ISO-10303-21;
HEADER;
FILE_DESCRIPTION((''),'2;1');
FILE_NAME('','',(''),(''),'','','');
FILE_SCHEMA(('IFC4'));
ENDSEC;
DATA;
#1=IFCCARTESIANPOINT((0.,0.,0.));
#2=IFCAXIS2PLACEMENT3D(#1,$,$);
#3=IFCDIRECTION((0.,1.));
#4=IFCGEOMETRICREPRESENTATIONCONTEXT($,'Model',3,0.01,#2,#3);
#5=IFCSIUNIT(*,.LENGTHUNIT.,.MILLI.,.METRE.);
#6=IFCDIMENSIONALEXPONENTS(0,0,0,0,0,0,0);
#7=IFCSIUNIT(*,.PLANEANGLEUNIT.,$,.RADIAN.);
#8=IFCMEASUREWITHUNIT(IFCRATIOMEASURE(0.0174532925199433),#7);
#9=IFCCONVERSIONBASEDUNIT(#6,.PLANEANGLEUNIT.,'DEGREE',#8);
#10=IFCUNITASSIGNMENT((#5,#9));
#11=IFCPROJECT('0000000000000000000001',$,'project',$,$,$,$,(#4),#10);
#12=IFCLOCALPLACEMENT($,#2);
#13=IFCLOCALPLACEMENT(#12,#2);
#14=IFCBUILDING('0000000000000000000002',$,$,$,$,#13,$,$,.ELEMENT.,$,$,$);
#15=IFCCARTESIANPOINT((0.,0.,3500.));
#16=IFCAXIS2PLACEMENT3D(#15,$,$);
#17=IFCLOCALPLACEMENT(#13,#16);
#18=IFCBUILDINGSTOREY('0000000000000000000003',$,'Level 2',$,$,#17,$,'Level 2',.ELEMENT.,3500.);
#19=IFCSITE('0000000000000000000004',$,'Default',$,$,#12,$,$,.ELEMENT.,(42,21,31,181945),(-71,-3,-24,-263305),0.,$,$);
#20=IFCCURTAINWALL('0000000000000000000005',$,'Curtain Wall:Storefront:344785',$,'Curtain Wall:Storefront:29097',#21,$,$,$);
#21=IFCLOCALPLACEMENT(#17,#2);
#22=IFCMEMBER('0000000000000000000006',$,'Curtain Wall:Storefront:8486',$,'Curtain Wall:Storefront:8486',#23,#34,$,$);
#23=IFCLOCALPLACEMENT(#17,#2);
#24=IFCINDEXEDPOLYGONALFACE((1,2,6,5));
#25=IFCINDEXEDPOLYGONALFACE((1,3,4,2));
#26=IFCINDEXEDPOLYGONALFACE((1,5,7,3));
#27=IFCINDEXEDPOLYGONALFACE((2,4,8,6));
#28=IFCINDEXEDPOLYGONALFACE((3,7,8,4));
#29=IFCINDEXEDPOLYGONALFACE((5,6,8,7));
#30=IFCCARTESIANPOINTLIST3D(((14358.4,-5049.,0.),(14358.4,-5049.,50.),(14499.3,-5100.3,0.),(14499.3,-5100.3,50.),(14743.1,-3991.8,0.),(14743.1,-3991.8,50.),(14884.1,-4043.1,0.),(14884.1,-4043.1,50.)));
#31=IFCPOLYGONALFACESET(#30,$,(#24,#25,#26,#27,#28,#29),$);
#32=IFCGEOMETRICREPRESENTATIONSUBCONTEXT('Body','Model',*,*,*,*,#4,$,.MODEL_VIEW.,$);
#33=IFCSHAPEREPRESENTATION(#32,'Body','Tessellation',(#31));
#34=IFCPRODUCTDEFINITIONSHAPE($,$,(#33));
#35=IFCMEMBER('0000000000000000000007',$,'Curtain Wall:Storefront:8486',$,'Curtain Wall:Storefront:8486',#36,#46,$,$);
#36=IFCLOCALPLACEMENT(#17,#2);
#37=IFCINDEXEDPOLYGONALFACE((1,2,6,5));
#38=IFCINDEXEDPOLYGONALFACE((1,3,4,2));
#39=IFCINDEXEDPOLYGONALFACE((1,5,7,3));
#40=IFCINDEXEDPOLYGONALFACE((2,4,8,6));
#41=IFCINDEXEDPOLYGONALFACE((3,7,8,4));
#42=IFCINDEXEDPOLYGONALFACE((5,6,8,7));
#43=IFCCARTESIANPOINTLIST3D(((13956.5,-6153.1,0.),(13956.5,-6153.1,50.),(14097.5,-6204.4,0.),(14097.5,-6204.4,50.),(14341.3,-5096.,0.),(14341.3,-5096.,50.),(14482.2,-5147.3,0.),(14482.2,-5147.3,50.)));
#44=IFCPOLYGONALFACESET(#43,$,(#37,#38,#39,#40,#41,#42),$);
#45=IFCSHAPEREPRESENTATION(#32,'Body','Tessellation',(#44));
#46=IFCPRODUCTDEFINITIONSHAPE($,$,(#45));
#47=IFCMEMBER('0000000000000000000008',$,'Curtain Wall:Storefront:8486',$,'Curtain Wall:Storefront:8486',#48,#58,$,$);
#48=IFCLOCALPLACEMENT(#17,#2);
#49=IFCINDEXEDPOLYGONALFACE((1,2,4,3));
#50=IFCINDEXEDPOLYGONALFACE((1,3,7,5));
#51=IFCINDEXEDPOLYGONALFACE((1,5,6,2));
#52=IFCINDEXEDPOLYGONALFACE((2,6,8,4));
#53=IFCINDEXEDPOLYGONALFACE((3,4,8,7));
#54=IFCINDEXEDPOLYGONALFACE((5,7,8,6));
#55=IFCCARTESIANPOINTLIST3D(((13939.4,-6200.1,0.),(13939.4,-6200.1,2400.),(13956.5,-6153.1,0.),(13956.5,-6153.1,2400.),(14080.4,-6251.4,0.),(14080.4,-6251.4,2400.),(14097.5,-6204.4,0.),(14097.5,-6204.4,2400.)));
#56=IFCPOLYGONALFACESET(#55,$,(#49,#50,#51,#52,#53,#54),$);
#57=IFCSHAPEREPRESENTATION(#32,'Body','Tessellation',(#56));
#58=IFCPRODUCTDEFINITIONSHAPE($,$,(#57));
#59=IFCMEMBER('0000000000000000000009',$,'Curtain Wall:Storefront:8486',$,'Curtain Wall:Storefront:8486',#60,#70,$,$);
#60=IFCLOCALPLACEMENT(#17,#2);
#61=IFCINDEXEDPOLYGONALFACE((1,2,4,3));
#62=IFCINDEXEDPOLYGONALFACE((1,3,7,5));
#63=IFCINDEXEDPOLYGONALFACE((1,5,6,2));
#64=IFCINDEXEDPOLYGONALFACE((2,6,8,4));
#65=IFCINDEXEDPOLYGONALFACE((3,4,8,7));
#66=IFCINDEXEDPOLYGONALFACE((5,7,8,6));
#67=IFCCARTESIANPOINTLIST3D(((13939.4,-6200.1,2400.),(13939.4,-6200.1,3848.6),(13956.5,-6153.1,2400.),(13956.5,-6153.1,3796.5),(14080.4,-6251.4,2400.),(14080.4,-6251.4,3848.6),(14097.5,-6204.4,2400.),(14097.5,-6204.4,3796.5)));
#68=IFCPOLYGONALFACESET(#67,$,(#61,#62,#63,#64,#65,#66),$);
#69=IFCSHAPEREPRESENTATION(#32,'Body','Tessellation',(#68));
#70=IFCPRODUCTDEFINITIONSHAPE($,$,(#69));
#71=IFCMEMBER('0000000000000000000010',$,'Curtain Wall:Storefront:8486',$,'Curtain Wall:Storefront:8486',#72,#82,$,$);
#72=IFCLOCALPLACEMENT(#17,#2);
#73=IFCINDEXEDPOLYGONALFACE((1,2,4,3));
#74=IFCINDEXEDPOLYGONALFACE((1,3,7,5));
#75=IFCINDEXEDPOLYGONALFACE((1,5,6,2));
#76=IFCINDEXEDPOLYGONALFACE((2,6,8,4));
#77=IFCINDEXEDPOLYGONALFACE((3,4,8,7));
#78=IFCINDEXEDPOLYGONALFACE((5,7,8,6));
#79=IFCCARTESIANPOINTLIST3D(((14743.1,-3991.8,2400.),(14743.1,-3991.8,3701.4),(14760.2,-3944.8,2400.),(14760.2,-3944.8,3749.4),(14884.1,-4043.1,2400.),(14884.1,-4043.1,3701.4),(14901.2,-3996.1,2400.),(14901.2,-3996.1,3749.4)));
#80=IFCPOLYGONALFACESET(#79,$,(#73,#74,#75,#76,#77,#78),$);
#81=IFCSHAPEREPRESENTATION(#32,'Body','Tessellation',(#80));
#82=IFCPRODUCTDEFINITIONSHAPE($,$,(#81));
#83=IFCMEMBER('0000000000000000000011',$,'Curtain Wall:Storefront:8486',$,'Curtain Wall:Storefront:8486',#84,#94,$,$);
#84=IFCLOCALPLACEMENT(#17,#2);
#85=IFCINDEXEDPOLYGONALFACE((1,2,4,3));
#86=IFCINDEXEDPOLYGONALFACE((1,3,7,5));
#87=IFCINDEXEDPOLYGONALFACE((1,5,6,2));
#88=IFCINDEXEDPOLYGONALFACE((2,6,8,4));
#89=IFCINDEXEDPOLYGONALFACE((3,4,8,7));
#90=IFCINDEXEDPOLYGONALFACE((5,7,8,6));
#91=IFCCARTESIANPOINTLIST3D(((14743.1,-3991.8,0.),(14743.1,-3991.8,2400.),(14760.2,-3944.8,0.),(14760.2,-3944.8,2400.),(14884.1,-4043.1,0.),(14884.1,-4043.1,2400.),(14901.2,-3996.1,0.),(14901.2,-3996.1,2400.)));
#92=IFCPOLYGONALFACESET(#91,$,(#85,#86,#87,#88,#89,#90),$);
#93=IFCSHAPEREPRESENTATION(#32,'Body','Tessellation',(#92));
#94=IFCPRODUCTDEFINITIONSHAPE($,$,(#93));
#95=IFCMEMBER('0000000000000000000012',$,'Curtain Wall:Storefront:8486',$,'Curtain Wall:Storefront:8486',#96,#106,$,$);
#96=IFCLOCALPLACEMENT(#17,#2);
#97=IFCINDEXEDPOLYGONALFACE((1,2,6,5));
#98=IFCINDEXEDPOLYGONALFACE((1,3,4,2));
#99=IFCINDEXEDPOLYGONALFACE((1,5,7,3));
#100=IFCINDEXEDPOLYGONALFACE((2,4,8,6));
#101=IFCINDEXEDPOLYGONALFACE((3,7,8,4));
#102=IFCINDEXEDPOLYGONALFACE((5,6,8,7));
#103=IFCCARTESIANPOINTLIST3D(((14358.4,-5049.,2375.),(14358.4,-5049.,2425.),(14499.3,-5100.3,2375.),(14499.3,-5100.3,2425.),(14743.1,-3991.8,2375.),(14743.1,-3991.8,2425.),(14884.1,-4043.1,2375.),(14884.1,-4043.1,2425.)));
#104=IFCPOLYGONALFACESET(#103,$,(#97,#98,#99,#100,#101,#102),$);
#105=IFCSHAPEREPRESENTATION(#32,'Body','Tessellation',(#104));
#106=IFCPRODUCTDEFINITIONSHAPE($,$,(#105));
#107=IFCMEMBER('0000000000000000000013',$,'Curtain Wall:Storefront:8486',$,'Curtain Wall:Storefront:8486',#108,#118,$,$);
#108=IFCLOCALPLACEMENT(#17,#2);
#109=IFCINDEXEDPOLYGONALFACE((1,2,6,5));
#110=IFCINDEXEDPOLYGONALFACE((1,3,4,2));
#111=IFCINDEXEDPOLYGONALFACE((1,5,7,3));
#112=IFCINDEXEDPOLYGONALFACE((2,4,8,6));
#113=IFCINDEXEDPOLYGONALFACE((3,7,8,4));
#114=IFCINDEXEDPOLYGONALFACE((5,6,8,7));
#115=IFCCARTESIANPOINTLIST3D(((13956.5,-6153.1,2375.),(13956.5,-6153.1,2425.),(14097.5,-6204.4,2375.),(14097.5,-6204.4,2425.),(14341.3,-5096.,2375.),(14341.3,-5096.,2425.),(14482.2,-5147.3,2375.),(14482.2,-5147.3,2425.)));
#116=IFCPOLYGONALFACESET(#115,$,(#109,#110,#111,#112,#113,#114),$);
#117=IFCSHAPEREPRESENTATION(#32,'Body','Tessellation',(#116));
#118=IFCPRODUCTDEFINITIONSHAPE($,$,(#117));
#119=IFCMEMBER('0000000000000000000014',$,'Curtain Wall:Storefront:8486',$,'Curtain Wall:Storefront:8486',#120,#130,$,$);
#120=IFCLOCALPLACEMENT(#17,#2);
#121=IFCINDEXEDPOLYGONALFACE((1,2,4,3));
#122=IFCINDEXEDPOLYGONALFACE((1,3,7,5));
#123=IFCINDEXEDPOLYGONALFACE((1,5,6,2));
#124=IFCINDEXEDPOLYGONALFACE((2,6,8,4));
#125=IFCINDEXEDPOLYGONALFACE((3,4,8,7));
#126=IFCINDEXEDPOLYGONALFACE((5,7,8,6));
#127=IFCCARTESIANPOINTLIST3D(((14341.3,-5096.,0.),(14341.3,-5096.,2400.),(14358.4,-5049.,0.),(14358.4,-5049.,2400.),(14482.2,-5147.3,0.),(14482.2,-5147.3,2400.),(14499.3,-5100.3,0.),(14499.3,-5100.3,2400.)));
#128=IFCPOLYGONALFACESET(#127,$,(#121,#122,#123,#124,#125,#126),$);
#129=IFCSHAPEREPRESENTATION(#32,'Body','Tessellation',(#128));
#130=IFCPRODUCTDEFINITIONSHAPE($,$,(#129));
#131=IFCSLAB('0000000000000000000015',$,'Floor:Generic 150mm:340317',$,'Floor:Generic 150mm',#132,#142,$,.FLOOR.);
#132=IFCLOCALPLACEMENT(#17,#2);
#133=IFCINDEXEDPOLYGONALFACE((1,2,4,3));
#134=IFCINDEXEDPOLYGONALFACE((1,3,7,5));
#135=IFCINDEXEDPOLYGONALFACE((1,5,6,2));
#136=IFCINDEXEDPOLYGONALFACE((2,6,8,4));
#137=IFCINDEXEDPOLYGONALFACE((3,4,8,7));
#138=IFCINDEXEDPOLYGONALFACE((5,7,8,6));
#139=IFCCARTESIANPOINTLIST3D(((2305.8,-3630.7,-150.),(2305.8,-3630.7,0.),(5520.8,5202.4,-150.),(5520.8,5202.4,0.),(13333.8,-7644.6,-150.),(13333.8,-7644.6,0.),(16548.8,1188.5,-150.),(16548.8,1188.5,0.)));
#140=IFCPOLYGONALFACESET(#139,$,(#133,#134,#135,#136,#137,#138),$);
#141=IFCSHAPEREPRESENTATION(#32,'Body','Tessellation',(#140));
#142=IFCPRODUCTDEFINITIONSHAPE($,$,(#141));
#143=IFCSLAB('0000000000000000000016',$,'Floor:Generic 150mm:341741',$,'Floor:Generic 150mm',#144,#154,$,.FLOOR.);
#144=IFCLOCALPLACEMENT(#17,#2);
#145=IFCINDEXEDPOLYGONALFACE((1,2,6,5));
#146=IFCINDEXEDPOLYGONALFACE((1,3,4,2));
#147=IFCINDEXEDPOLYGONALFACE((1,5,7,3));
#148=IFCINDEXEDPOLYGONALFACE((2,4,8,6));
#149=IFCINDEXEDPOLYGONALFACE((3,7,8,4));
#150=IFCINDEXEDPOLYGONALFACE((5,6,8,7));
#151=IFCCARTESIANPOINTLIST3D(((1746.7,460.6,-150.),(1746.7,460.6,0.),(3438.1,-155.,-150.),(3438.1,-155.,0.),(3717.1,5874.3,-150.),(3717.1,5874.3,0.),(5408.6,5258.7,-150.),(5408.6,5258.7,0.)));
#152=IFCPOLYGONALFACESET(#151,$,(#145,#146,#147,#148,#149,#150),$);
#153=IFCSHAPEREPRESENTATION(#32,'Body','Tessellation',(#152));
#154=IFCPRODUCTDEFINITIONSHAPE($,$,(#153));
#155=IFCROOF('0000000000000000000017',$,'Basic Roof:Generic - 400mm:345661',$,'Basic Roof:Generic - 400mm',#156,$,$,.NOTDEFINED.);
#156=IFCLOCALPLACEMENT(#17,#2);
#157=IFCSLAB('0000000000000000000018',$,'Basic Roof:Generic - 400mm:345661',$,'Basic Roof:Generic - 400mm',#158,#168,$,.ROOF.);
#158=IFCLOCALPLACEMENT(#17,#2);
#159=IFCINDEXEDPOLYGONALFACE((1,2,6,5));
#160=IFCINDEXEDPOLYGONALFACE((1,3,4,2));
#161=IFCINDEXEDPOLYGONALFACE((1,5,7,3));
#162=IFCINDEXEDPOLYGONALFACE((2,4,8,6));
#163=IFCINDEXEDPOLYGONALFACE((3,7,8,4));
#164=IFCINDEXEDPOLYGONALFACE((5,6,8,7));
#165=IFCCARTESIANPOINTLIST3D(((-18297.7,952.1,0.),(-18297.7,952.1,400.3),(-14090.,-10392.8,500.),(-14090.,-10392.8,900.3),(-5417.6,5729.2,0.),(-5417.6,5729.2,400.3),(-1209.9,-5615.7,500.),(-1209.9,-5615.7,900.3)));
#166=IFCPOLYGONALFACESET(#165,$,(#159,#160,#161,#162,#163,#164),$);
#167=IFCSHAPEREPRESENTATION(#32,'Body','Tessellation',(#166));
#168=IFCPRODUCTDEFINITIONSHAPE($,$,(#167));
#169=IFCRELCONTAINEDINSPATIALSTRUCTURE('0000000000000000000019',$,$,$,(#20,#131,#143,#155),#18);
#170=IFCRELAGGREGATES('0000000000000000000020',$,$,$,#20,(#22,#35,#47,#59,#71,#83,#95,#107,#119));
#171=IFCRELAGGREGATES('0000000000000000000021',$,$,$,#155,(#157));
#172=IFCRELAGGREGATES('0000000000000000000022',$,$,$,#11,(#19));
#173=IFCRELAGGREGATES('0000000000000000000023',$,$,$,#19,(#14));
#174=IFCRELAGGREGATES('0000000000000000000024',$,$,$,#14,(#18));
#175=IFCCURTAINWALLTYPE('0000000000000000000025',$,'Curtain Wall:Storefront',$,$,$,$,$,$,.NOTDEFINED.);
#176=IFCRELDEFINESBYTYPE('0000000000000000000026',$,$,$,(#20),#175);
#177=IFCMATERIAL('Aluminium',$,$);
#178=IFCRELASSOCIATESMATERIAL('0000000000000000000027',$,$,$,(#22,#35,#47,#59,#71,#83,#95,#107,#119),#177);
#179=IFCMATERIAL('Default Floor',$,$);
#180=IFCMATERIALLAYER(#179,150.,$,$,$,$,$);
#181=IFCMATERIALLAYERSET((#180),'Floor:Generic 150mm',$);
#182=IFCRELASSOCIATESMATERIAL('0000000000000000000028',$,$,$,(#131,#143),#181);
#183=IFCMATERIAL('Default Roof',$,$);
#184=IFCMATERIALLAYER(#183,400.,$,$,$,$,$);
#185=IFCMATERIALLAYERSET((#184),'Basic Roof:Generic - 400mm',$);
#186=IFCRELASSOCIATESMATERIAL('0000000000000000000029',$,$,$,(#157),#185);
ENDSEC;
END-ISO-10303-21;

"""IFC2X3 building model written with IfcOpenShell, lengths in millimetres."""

from ifc_helpers import new_model, entity, si_unit, converted_unit, direction, frame, frame_2d, origin, origin_2d_with_axis, place, context, subcontext, project, spatial, rectangle, extrude, clip, halfspace, material, layer, layer_set, layer_usage, type_object, element, aggregate, save


model = new_model("IFC2X3")

# Units and contexts
model_context = context("Model", 3, precision=0.01, world=origin(), true_north=direction((0.0, 1.0)))
body_context = subcontext(model_context, "Body", "Model", "MODEL_VIEW")
ifc_project = project(units=[si_unit("LENGTHUNIT", "METRE", prefix="MILLI"), converted_unit("PLANEANGLEUNIT", "DEGREE", entity("IfcRatioMeasure", 0.0174532925199433), si_unit("PLANEANGLEUNIT", "RADIAN"), dimensions=[0, 0, 0, 0, 0, 0, 0])], contexts=[model_context])

# Site, building, storey
site_placement = place(None, origin())
site = spatial("IfcSite", under=ifc_project, at=site_placement, Name="Default", CompositionType="ELEMENT", RefLatitude=(42, 21, 31, 181945), RefLongitude=(-71, -3, -24, -263305), RefElevation=0.0)
building_placement = place(site_placement, origin())
building = spatial("IfcBuilding", under=site, at=building_placement, CompositionType="ELEMENT")
storey_placement = place(building_placement, frame((0.0, 0.0, 3500.0)))
storey = spatial("IfcBuildingStorey", under=building, at=storey_placement, Name="Level 2", LongName="Level 2", CompositionType="ELEMENT", Elevation=3500.0)

# Curtain wall, members
curtain_wall_type = type_object("IfcCurtainWallType", Name="Curtain Wall:Storefront", PredefinedType="NOTDEFINED")
curtain_wall_placement = place(storey_placement, frame((0.0, 0.0, -3500.0)))
curtain_wall = element("IfcCurtainWall", 1, at=curtain_wall_placement, inside=storey, type_object=curtain_wall_type, Name="Curtain Wall:Storefront:344785", ObjectType="Curtain Wall:Storefront:29097")
ifc_material_1 = material(Name="Aluminium")
member_1_placement = place(curtain_wall_placement, frame((0.0, 0.0, 3500.0)))
member_1 = element("IfcMember", 2, at=member_1_placement, material=ifc_material_1, Name="Curtain Wall:Storefront:8486", ObjectType="Curtain Wall:Storefront:8486", context=body_context, shape_type="SweptSolid", body=[
    extrude(rectangle(XDim=50.0, YDim=150.0, at=frame_2d((0.0, 0.0), x_axis=(1.0, 0.0))), frame((14813.6, -4017.5, 25.0), z_axis=(-0.34202, -0.939693, 0.0), x_axis=(0.0, 0.0, -1.0)), (0.0, 0.0, 1.0), 1125.0),
])
member_2_placement = place(curtain_wall_placement, frame((0.0, 0.0, 3500.0)))
member_2 = element("IfcMember", 3, at=member_2_placement, material=ifc_material_1, Name="Curtain Wall:Storefront:8486", ObjectType="Curtain Wall:Storefront:8486", context=body_context, shape_type="SweptSolid", body=[
    extrude(rectangle(XDim=50.0, YDim=150.0, at=frame_2d((0.0, 0.0), x_axis=(1.0, 0.0))), frame((14411.8, -5121.6, 25.0), z_axis=(-0.34202, -0.939693, 0.0), x_axis=(0.0, 0.0, -1.0)), (0.0, 0.0, 1.0), 1125.0),
])
member_3_placement = place(curtain_wall_placement, frame((0.0, 0.0, 3500.0)))
member_3 = element("IfcMember", 4, at=member_3_placement, material=ifc_material_1, Name="Curtain Wall:Storefront:8486", ObjectType="Curtain Wall:Storefront:8486", context=body_context, shape_type="SweptSolid", body=[
    extrude(rectangle(XDim=150.0, YDim=50.0, at=origin_2d_with_axis()), frame((14018.4, -6202.3, 0.0), z_axis=(0.0, 0.0, 1.0), x_axis=(0.939693, -0.34202, 0.0)), (0.0, 0.0, 1.0), 2400.0),
])
member_4_placement = place(curtain_wall_placement, frame((0.0, 0.0, 3500.0)))
member_4 = element("IfcMember", 5, at=member_4_placement, material=ifc_material_1, Name="Curtain Wall:Storefront:8486", ObjectType="Curtain Wall:Storefront:8486", context=body_context, shape_type="Clipping", body=[
    clip(extrude(rectangle(XDim=150.0, YDim=50.0, at=origin_2d_with_axis()), frame((14018.4, -6202.3, 2400.0), z_axis=(0.0, 0.0, 1.0), x_axis=(0.939693, -0.34202, 0.0)), (0.0, 0.0, 1.0), 1448.6), halfspace(frame((14296.3, -6330.0, 3848.6), z_axis=(0.246787, 0.678041, 0.692356), x_axis=(0.2368, 0.650602, -0.721556)), False)),
])
member_5_placement = place(curtain_wall_placement, frame((0.0, 0.0, 3500.0)))
member_5 = element("IfcMember", 6, at=member_5_placement, material=ifc_material_1, Name="Curtain Wall:Storefront:8486", ObjectType="Curtain Wall:Storefront:8486", context=body_context, shape_type="Clipping", body=[
    clip(extrude(rectangle(XDim=150.0, YDim=50.0, at=frame_2d((0.0, 0.0), x_axis=(1.0, 0.0))), frame((14822.2, -3994.0, 3749.4), z_axis=(0.0, 0.0, -1.0), x_axis=(0.939693, -0.34202, 0.0)), (0.0, 0.0, 1.0), 1349.4), halfspace(frame((15117.1, -4074.7, 3749.4), z_axis=(-0.2368, -0.650602, 0.721556), x_axis=(-0.246787, -0.678041, -0.692356)), False)),
])
member_6_placement = place(curtain_wall_placement, frame((0.0, 0.0, 3500.0)))
member_6 = element("IfcMember", 7, at=member_6_placement, material=ifc_material_1, Name="Curtain Wall:Storefront:8486", ObjectType="Curtain Wall:Storefront:8486", context=body_context, shape_type="SweptSolid", body=[
    extrude(rectangle(XDim=150.0, YDim=50.0, at=frame_2d((0.0, 0.0), x_axis=(1.0, 0.0))), frame((14822.2, -3994.0, 2400.0), z_axis=(0.0, 0.0, -1.0), x_axis=(0.939693, -0.34202, 0.0)), (0.0, 0.0, 1.0), 2400.0),
])
member_7_placement = place(curtain_wall_placement, frame((0.0, 0.0, 3500.0)))
member_7 = element("IfcMember", 8, at=member_7_placement, material=ifc_material_1, Name="Curtain Wall:Storefront:8486", ObjectType="Curtain Wall:Storefront:8486", context=body_context, shape_type="SweptSolid", body=[
    extrude(rectangle(XDim=50.0, YDim=150.0, at=origin_2d_with_axis()), frame((14428.9, -5074.6, 2400.0), z_axis=(0.34202, 0.939693, 0.0), x_axis=(0.0, 0.0, -1.0)), (0.0, 0.0, 1.0), 1125.0),
])
member_8_placement = place(curtain_wall_placement, frame((0.0, 0.0, 3500.0)))
member_8 = element("IfcMember", 9, at=member_8_placement, material=ifc_material_1, Name="Curtain Wall:Storefront:8486", ObjectType="Curtain Wall:Storefront:8486", context=body_context, shape_type="SweptSolid", body=[
    extrude(rectangle(XDim=50.0, YDim=150.0, at=origin_2d_with_axis()), frame((14027.0, -6178.8, 2400.0), z_axis=(0.34202, 0.939693, 0.0), x_axis=(0.0, 0.0, -1.0)), (0.0, 0.0, 1.0), 1125.0),
])
member_9_placement = place(curtain_wall_placement, frame((0.0, 0.0, 3500.0)))
member_9 = element("IfcMember", 10, at=member_9_placement, material=ifc_material_1, Name="Curtain Wall:Storefront:8486", ObjectType="Curtain Wall:Storefront:8486", context=body_context, shape_type="SweptSolid", body=[
    extrude(rectangle(XDim=150.0, YDim=50.0, at=frame_2d((0.0, 0.0), x_axis=(1.0, 0.0))), frame((14420.3, -5098.1, 0.0), z_axis=(0.0, 0.0, 1.0), x_axis=(0.939693, -0.34202, 0.0)), (0.0, 0.0, 1.0), 2400.0),
])
aggregate(curtain_wall, [member_1, member_2, member_3, member_4, member_5, member_6, member_7, member_8, member_9])

# Slabs
ifc_material_2 = material(Name="Default Floor")
ifc_layer_1 = layer(ifc_material_2, 150.0)
ifc_layer_set_1 = layer_set([ifc_layer_1], Name="Floor:Generic 150mm")
ifc_layer_usage_1 = layer_usage(ifc_layer_set_1, "AXIS3", "POSITIVE", 0.0)
slab_1_placement = place(storey_placement, origin())
element("IfcSlab", 11, at=slab_1_placement, inside=storey, material=ifc_layer_usage_1, Name="Floor:Generic 150mm:340317", ObjectType="Floor:Generic 150mm", PredefinedType="FLOOR", context=body_context, shape_type="SweptSolid", body=[
    extrude(rectangle(XDim=11735.8, YDim=9400.0, at=frame_2d((0.0, 0.0), x_axis=(1.0, 0.0))), frame((9427.3, -1221.1, 0.0), z_axis=(0.0, 0.0, -1.0), x_axis=(0.939693, -0.34202, 0.0)), (0.0, 0.0, 1.0), 150.0),
])
ifc_layer_usage_2 = layer_usage(ifc_layer_set_1, "AXIS3", "POSITIVE", 0.0)
slab_2_placement = place(storey_placement, origin())
element("IfcSlab", 12, at=slab_2_placement, inside=storey, material=ifc_layer_usage_2, Name="Floor:Generic 150mm:341741", ObjectType="Floor:Generic 150mm", PredefinedType="FLOOR", context=body_context, shape_type="SweptSolid", body=[
    extrude(rectangle(XDim=5761.2, YDim=1800.0, at=frame_2d((0.0, 0.0), x_axis=(1.0, 0.0))), frame((3577.6, 2859.6, 0.0), z_axis=(0.0, 0.0, -1.0), x_axis=(-0.34202, -0.939693, 0.0)), (0.0, 0.0, 1.0), 150.0),
])

# Roof, slab
roof_placement = place(storey_placement, frame((-18297.7, -10392.8, 0.0)))
roof = element("IfcRoof", 13, at=roof_placement, inside=storey, Name="Basic Roof:Generic - 400mm:345661", ObjectType="Basic Roof:Generic - 400mm", ShapeType="NOTDEFINED")
ifc_material_3 = material(Name="Default Roof")
ifc_layer_2 = layer(ifc_material_3, 400.0)
ifc_layer_set_2 = layer_set([ifc_layer_2], Name="Basic Roof:Generic - 400mm")
slab_3_placement = place(roof_placement, origin())
slab_3 = element("IfcSlab", 14, at=slab_3_placement, material=ifc_layer_set_2, Name="Basic Roof:Generic - 400mm:345661", ObjectType="Basic Roof:Generic - 400mm", PredefinedType="ROOF", context=body_context, shape_type="SweptSolid", body=[
    extrude(rectangle(XDim=13737.4, YDim=12110.3, at=frame_2d((0.0, 0.0), x_axis=(0.937686, 0.347484))), frame((8543.9, 8061.0, 250.0), z_axis=(-0.014357, 0.03871, 0.999147), x_axis=(0.999897, 0.000556, 0.014347)), (0.014347, -0.038714, 0.999147), 400.3),
])
aggregate(roof, [slab_3])

save(model, "model.ifc")
